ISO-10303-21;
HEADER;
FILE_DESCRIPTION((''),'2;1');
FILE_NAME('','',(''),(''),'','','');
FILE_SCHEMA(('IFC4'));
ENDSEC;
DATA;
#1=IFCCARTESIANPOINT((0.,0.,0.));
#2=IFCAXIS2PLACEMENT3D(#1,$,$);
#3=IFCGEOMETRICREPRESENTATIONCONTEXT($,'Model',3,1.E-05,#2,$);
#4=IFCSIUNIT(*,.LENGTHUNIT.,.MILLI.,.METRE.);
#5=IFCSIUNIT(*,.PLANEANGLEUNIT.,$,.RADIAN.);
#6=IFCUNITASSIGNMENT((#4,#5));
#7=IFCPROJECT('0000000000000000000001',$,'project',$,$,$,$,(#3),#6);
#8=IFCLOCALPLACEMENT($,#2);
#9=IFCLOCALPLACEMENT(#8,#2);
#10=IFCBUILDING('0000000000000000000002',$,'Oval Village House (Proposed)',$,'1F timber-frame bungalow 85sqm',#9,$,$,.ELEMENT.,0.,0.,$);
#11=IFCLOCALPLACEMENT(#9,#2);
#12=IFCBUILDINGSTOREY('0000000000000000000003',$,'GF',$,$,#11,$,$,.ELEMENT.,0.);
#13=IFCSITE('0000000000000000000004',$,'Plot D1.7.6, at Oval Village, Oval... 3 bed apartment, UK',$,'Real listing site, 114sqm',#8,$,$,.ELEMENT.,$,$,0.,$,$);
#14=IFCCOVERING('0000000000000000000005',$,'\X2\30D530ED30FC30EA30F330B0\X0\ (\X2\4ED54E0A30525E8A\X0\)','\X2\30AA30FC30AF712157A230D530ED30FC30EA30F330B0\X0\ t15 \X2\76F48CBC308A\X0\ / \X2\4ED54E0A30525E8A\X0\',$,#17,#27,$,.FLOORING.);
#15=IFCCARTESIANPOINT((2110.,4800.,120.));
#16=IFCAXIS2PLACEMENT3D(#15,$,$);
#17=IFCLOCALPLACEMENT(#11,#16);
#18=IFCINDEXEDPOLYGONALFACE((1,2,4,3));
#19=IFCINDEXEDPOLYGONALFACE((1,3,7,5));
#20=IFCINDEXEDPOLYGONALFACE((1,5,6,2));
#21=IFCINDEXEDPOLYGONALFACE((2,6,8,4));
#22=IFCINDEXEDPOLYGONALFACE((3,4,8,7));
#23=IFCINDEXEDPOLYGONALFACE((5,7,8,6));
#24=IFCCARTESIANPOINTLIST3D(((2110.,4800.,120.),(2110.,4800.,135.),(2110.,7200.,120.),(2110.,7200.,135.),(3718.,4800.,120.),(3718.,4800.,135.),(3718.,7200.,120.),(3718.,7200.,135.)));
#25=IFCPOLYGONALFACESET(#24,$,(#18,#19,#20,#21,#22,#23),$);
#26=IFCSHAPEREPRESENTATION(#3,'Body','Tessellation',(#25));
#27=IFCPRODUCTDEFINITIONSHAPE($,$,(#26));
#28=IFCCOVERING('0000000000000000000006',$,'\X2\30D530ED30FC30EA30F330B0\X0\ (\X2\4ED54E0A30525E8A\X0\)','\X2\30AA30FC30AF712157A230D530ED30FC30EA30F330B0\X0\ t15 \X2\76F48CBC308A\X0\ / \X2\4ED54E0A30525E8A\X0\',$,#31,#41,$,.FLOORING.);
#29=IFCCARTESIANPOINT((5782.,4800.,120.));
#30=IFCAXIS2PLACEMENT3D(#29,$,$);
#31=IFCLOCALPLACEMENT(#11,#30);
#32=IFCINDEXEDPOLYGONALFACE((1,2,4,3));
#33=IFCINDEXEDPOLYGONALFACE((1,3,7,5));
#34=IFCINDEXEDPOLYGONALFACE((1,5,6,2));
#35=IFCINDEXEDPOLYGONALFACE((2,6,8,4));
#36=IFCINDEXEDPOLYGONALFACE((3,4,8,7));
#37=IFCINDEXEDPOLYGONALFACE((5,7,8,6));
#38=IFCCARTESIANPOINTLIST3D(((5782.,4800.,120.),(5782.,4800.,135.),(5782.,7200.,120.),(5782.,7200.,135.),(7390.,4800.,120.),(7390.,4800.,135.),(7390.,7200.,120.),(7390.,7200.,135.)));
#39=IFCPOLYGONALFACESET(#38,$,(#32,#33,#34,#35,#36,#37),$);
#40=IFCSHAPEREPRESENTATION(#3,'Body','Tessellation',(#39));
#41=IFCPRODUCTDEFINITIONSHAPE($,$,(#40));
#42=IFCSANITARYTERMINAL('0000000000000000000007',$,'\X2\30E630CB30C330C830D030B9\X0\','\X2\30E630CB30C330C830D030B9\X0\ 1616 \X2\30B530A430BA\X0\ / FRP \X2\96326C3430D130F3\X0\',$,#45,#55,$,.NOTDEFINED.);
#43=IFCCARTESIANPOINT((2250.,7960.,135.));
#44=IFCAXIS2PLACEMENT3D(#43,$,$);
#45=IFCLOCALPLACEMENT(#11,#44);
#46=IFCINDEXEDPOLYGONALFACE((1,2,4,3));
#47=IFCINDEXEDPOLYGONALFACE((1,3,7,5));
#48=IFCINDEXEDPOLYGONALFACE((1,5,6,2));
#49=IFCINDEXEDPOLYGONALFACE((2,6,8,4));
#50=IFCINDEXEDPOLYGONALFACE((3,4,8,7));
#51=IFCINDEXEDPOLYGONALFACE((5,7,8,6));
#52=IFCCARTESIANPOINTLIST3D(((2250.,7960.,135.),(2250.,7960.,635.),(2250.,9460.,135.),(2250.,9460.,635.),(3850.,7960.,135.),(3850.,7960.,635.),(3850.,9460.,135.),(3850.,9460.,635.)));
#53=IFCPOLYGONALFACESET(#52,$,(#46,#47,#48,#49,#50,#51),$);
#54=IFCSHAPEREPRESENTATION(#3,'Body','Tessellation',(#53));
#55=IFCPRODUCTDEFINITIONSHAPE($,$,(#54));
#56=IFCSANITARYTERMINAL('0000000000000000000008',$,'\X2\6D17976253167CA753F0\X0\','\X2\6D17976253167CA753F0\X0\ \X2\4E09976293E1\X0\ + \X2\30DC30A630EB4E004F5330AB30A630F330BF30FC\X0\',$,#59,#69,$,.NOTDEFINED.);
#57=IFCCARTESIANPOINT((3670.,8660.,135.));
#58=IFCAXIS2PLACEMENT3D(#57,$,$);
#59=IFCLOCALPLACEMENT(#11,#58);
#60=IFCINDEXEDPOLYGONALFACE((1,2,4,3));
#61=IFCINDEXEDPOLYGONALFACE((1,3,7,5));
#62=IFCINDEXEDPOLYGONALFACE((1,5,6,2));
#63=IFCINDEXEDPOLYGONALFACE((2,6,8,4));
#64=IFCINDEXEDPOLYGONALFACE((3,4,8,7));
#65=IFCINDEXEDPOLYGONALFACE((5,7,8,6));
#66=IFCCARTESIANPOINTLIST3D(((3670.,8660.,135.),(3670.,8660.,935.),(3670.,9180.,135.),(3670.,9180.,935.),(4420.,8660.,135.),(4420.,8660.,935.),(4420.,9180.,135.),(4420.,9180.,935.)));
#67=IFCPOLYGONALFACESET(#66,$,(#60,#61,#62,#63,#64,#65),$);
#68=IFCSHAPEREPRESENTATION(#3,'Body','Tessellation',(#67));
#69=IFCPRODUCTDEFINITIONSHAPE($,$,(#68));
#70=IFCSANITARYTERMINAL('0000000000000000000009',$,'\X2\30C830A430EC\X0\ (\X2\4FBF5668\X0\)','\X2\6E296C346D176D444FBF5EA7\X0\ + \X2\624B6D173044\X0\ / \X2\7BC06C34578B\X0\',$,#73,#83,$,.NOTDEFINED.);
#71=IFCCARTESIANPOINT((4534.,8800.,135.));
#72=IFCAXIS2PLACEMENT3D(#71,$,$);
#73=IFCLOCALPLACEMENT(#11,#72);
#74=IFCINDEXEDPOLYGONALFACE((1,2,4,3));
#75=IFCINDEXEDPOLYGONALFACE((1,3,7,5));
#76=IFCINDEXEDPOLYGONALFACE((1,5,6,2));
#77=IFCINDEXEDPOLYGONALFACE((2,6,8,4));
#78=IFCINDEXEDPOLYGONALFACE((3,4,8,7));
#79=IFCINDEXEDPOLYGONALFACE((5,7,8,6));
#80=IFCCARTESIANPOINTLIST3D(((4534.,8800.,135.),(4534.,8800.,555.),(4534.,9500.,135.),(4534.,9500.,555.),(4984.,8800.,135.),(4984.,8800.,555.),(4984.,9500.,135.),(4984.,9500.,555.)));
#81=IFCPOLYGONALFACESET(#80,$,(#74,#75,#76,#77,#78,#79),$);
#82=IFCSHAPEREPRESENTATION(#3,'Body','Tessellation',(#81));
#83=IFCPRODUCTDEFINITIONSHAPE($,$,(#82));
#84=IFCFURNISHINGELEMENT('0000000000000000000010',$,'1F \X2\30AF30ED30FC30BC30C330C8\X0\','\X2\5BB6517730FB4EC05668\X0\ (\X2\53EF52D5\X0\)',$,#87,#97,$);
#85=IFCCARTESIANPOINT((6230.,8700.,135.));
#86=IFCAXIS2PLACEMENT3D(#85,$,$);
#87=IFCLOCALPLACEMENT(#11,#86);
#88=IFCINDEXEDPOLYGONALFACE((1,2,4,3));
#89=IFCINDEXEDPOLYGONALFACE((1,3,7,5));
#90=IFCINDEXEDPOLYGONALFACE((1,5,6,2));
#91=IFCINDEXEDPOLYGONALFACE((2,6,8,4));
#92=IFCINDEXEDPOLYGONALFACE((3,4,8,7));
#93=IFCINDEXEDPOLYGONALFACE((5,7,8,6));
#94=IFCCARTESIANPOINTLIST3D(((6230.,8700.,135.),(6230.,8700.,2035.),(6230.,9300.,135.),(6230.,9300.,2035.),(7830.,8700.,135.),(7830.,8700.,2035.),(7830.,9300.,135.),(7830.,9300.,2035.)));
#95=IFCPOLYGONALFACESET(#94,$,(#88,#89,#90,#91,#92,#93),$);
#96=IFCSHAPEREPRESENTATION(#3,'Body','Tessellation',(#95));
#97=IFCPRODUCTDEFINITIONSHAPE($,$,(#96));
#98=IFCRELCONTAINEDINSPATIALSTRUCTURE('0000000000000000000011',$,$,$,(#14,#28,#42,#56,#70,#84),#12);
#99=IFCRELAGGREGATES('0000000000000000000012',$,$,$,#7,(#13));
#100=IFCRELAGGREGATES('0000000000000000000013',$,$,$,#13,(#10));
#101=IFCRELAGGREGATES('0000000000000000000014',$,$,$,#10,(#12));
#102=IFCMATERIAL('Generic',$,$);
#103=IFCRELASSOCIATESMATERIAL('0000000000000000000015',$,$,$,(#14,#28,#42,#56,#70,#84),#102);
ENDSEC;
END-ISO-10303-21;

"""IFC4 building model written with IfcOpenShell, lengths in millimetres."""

from ifc_helpers import new_model, si_unit, frame, frame_2d, origin, place, context, project, spatial, rectangle, extrude, material, element, save


model = new_model("IFC4")

# Units and contexts
model_context = context("Model", 3, precision=1e-05, world=origin())
ifc_project = project(units=[si_unit("LENGTHUNIT", "METRE", prefix="MILLI"), si_unit("PLANEANGLEUNIT", "RADIAN")], contexts=[model_context])

# Site, building, storey
site_placement = place(None, origin())
site = spatial("IfcSite", under=ifc_project, at=site_placement, Name="Plot D1.7.6, at Oval Village, Oval... 3 bed apartment, UK", ObjectType="Real listing site, 114sqm", CompositionType="ELEMENT", RefElevation=0.0)
building_placement = place(site_placement, origin())
building = spatial("IfcBuilding", under=site, at=building_placement, Name="Oval Village House (Proposed)", ObjectType="1F timber-frame bungalow 85sqm", CompositionType="ELEMENT", ElevationOfRefHeight=0.0, ElevationOfTerrain=0.0)
storey_placement = place(building_placement, origin())
storey = spatial("IfcBuildingStorey", under=building, at=storey_placement, Name="GF", CompositionType="ELEMENT", Elevation=0.0)

# Coverings
ifc_material_1 = material(Name="Generic")
covering_1_placement = place(storey_placement, frame((2110.0, 4800.0, 120.0)))
element("IfcCovering", 1, at=covering_1_placement, inside=storey, material=ifc_material_1, Name="フローリング (仕上げ床)", Description="オーク無垢フローリング t15 直貼り / 仕上げ床", PredefinedType="FLOORING", context=model_context, shape_type="SweptSolid", body=[
    extrude(rectangle(XDim=1608.0, YDim=2400.0, at=frame_2d((804.0, 1200.0))), frame((2110.0, 4800.0, 120.0)), (0.0, 0.0, 1.0), 15.0),
])
covering_2_placement = place(storey_placement, frame((5782.0, 4800.0, 120.0)))
element("IfcCovering", 2, at=covering_2_placement, inside=storey, material=ifc_material_1, Name="フローリング (仕上げ床)", Description="オーク無垢フローリング t15 直貼り / 仕上げ床", PredefinedType="FLOORING", context=model_context, shape_type="SweptSolid", body=[
    extrude(rectangle(XDim=1608.0, YDim=2400.0, at=frame_2d((804.0, 1200.0))), frame((5782.0, 4800.0, 120.0)), (0.0, 0.0, 1.0), 15.0),
])

# Sanitary terminals
sanitary_terminal_1_placement = place(storey_placement, frame((2250.0, 7960.0, 135.0)))
element("IfcSanitaryTerminal", 3, at=sanitary_terminal_1_placement, inside=storey, material=ifc_material_1, Name="ユニットバス", Description="ユニットバス 1616 サイズ / FRP 防水パン", PredefinedType="NOTDEFINED", context=model_context, shape_type="SweptSolid", body=[
    extrude(rectangle(XDim=1600.0, YDim=1500.0, at=frame_2d((800.0, 750.0))), frame((2250.0, 7960.0, 135.0)), (0.0, 0.0, 1.0), 500.0),
])
sanitary_terminal_2_placement = place(storey_placement, frame((3670.0, 8660.0, 135.0)))
element("IfcSanitaryTerminal", 4, at=sanitary_terminal_2_placement, inside=storey, material=ifc_material_1, Name="洗面化粧台", Description="洗面化粧台 三面鏡 + ボウル一体カウンター", PredefinedType="NOTDEFINED", context=model_context, shape_type="SweptSolid", body=[
    extrude(rectangle(XDim=750.0, YDim=520.0, at=frame_2d((375.0, 260.0))), frame((3670.0, 8660.0, 135.0)), (0.0, 0.0, 1.0), 800.0),
])
sanitary_terminal_3_placement = place(storey_placement, frame((4534.0, 8800.0, 135.0)))
element("IfcSanitaryTerminal", 5, at=sanitary_terminal_3_placement, inside=storey, material=ifc_material_1, Name="トイレ (便器)", Description="温水洗浄便座 + 手洗い / 節水型", PredefinedType="NOTDEFINED", context=model_context, shape_type="SweptSolid", body=[
    extrude(rectangle(XDim=450.0, YDim=700.0, at=frame_2d((225.0, 350.0))), frame((4534.0, 8800.0, 135.0)), (0.0, 0.0, 1.0), 420.0),
])

# Furnishing element
furnishing_placement = place(storey_placement, frame((6230.0, 8700.0, 135.0)))
element("IfcFurnishingElement", 6, at=furnishing_placement, inside=storey, material=ifc_material_1, Name="1F クローゼット", Description="家具・什器 (可動)", context=model_context, shape_type="SweptSolid", body=[
    extrude(rectangle(XDim=1600.0, YDim=600.0, at=frame_2d((800.0, 300.0))), frame((6230.0, 8700.0, 135.0)), (0.0, 0.0, 1.0), 1900.0),
])

save(model, "model.ifc")
